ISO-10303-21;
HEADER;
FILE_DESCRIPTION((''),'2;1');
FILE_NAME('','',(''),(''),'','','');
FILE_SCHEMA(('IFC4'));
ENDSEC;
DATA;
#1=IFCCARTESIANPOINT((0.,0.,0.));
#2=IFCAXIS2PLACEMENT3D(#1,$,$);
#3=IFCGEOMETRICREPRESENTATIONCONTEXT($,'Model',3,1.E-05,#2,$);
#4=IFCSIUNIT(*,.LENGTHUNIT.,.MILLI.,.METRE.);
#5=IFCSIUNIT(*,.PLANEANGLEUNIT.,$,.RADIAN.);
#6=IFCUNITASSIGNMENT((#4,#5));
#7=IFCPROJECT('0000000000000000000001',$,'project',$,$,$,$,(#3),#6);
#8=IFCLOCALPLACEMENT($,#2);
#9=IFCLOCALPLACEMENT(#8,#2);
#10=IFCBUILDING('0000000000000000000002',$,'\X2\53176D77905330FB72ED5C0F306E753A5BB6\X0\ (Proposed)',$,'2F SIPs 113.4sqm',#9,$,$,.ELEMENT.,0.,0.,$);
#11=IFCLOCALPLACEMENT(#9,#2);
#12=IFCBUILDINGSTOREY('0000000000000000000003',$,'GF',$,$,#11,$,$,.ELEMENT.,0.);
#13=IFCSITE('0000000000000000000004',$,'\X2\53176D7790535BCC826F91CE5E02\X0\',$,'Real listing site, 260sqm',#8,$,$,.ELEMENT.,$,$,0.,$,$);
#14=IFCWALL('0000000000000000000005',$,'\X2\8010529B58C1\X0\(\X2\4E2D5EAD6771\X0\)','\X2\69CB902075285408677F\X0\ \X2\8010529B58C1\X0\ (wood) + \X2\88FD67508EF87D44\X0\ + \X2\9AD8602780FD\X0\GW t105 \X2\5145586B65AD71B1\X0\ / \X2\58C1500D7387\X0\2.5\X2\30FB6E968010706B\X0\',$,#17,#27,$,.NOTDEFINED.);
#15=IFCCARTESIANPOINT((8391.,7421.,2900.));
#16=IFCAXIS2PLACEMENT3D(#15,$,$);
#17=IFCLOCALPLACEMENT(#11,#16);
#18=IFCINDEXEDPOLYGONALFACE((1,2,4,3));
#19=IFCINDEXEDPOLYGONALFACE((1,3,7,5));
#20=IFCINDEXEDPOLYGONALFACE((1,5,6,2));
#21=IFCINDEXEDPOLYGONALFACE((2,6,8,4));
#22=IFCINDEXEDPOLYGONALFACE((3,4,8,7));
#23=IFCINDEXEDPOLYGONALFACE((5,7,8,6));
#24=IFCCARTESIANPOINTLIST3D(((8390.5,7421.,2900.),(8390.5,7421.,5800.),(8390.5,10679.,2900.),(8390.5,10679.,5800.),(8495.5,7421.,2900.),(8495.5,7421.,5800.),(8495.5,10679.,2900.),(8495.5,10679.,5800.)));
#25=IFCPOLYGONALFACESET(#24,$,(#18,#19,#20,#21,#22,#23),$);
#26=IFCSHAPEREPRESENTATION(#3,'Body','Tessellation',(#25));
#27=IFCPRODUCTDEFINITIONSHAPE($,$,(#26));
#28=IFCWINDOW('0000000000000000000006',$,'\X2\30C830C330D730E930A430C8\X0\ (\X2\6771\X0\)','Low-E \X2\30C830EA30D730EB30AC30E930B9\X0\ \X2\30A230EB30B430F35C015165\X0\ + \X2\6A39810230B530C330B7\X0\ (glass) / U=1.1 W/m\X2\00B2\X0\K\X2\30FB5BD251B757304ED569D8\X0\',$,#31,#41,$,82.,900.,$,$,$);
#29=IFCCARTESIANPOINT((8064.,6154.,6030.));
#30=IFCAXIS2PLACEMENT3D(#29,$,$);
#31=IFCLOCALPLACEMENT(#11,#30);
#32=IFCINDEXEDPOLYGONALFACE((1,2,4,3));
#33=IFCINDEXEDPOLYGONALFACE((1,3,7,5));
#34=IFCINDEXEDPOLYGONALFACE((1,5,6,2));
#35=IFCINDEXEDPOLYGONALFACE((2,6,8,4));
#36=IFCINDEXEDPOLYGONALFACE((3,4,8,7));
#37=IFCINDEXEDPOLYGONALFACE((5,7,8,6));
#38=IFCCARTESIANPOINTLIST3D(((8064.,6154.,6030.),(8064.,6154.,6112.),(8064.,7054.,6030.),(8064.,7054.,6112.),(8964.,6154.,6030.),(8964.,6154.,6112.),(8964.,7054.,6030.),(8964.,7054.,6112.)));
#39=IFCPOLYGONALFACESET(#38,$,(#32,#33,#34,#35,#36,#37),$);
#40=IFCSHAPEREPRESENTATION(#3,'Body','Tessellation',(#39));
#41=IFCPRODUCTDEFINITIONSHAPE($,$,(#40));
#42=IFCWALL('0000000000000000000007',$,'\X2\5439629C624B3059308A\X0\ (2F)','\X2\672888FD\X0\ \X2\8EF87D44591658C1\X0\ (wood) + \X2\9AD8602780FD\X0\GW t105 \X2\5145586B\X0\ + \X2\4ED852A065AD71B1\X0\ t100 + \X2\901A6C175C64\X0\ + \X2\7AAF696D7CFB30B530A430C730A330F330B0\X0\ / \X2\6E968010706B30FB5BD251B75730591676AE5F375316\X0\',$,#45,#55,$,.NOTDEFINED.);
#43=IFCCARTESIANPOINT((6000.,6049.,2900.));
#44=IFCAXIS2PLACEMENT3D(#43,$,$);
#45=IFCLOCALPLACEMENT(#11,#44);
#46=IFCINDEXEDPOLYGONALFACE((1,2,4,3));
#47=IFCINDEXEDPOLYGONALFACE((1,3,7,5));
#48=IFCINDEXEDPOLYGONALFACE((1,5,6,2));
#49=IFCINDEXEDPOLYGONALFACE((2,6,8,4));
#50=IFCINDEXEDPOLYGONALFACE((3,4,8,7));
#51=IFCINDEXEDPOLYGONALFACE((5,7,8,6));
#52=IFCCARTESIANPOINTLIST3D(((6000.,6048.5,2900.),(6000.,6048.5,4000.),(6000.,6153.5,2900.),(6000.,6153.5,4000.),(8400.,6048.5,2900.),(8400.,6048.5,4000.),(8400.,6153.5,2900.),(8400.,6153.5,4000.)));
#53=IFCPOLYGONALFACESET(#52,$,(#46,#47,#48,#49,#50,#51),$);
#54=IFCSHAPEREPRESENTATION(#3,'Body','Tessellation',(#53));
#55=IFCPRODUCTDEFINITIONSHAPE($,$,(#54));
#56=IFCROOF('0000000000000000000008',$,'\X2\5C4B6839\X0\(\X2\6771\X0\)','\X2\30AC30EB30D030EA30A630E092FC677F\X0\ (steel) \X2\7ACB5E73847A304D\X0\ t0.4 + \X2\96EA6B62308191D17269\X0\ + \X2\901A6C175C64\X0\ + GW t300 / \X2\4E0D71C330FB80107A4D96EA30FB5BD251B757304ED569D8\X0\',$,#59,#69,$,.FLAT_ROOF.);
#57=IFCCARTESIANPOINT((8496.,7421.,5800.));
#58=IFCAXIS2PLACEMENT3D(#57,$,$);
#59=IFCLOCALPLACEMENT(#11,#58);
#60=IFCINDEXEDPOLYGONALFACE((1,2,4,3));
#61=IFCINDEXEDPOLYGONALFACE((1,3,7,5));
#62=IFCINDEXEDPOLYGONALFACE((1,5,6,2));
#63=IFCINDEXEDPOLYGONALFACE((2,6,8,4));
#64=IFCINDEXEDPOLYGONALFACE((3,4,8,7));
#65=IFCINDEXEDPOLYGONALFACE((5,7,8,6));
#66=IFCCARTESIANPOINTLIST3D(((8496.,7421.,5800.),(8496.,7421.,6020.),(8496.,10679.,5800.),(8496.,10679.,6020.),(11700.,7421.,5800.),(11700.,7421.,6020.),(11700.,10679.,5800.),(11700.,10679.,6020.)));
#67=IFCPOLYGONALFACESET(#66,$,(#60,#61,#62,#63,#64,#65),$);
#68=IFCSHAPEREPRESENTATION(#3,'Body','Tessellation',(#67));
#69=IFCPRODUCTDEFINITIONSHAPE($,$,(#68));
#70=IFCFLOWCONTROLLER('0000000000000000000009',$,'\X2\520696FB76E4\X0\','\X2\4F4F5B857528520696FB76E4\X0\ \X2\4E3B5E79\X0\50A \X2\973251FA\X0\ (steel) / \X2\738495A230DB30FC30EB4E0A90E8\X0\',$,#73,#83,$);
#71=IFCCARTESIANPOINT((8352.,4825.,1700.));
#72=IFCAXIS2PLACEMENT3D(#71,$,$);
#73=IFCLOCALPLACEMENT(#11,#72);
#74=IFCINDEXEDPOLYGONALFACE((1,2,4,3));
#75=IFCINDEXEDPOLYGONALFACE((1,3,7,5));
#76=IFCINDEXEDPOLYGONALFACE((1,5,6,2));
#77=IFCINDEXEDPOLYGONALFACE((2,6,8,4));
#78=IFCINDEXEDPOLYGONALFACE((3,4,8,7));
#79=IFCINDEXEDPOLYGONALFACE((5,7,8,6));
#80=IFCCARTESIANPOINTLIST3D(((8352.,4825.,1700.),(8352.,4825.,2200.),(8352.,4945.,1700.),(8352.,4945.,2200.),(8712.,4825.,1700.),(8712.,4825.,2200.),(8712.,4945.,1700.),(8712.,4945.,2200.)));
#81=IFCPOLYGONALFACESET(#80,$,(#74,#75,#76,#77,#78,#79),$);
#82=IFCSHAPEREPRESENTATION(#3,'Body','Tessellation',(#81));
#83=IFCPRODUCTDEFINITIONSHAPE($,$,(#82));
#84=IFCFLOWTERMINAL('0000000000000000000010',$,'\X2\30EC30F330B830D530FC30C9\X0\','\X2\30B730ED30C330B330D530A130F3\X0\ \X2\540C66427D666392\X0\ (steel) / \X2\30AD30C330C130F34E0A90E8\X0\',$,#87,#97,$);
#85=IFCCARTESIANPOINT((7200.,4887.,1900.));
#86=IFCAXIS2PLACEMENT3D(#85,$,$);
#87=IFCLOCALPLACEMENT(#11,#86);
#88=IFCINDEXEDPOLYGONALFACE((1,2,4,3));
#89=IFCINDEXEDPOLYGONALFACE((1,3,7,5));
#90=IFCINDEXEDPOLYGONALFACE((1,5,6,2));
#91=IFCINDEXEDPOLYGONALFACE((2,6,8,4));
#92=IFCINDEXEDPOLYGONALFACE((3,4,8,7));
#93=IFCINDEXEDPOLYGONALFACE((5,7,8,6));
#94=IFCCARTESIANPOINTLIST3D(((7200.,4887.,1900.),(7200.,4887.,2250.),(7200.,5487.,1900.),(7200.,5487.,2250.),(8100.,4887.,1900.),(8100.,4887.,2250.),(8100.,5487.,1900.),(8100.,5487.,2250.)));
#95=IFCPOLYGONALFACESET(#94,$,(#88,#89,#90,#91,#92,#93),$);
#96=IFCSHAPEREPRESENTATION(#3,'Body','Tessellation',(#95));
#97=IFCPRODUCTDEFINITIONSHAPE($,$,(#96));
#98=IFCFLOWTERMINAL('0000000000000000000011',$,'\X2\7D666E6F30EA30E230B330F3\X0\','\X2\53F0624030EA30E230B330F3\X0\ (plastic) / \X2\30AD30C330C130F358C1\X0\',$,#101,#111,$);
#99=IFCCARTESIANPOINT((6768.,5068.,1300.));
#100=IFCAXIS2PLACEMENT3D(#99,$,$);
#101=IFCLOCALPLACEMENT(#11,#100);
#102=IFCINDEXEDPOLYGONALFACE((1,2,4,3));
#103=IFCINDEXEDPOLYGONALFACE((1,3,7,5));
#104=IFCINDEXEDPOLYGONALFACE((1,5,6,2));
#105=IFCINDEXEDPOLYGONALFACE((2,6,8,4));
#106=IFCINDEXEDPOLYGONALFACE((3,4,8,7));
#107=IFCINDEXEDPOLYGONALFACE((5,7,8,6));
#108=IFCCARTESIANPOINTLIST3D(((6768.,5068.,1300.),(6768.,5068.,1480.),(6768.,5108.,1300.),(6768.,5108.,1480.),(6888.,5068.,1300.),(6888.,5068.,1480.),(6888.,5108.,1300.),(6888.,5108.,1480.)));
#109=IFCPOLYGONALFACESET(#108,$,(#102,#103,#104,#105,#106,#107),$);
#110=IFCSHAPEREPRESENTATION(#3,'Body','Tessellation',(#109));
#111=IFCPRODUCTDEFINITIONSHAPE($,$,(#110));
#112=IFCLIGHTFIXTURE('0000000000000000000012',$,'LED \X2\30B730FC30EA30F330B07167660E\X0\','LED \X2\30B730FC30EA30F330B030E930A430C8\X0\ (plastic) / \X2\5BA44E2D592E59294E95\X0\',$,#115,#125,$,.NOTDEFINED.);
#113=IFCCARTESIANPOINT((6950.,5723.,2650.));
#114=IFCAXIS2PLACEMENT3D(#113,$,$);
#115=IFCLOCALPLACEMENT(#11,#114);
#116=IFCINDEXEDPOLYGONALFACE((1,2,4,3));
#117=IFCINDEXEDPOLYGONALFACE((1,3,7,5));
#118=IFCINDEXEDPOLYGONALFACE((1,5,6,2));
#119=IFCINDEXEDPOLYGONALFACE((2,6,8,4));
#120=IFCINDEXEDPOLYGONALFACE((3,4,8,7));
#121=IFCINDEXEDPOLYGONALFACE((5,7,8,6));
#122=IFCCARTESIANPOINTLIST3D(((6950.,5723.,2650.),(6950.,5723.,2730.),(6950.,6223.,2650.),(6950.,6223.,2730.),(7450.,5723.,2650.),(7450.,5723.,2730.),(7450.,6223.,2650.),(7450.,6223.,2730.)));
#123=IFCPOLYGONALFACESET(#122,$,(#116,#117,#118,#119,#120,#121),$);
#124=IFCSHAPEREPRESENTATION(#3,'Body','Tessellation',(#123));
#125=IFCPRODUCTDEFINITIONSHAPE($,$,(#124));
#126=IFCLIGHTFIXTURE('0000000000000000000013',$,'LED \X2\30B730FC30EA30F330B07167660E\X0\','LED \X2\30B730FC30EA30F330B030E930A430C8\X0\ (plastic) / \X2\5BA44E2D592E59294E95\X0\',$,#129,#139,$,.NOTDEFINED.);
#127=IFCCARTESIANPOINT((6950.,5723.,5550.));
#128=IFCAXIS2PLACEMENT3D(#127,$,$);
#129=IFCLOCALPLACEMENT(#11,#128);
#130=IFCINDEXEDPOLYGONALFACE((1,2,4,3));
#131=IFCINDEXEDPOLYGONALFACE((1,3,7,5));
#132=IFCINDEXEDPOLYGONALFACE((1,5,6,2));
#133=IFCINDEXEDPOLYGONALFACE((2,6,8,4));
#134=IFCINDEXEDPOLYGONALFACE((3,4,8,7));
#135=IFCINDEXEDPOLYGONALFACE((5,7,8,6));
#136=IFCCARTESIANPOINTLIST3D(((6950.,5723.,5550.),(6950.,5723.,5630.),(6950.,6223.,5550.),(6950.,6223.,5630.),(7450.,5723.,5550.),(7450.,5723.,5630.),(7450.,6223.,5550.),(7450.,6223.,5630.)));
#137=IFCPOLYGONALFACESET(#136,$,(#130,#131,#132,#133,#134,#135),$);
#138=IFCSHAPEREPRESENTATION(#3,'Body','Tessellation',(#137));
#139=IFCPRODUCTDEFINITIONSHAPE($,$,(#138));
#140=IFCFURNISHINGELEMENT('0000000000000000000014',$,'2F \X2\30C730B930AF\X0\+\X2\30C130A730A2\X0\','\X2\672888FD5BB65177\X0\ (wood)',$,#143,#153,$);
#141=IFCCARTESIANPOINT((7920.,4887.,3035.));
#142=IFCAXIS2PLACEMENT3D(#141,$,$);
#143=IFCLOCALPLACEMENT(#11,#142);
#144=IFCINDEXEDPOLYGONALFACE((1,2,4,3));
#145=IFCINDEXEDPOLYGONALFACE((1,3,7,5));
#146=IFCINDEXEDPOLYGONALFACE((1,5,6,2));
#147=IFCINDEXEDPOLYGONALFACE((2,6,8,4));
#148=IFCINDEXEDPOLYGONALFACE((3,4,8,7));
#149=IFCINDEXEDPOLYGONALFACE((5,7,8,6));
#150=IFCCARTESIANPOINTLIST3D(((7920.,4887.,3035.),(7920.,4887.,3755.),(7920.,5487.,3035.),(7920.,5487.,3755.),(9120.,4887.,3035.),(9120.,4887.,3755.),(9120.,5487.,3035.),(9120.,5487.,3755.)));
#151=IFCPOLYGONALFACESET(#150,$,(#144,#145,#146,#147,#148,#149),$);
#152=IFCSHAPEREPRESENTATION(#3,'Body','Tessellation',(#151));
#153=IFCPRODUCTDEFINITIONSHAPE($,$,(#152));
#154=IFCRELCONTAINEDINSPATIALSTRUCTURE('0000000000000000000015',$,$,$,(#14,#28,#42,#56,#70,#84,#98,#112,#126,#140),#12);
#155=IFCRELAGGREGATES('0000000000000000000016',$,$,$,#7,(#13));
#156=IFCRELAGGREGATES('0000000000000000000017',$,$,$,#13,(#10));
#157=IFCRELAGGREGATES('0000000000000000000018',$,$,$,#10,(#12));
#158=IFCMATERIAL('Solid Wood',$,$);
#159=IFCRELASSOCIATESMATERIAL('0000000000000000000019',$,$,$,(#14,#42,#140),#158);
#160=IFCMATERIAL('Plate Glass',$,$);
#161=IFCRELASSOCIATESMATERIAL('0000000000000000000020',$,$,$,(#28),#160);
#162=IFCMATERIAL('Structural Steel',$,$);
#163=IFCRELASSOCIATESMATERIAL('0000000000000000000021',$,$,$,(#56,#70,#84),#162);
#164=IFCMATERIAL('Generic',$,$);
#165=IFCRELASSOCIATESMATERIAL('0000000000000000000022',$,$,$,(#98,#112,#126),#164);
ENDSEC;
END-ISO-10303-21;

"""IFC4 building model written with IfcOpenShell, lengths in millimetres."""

from ifc_helpers import new_model, si_unit, frame, frame_2d, origin, place, context, project, spatial, rectangle, extrude, material, element, save


model = new_model("IFC4")

# Units and contexts
model_context = context("Model", 3, precision=1e-05, world=origin())
ifc_project = project(units=[si_unit("LENGTHUNIT", "METRE", prefix="MILLI"), si_unit("PLANEANGLEUNIT", "RADIAN")], contexts=[model_context])

# Site, building, storey
site_placement = place(None, origin())
site = spatial("IfcSite", under=ifc_project, at=site_placement, Name="北海道富良野市", ObjectType="Real listing site, 260sqm", CompositionType="ELEMENT", RefElevation=0.0)
building_placement = place(site_placement, origin())
building = spatial("IfcBuilding", under=site, at=building_placement, Name="北海道・狭小の町家 (Proposed)", ObjectType="2F SIPs 113.4sqm", CompositionType="ELEMENT", ElevationOfRefHeight=0.0, ElevationOfTerrain=0.0)
storey_placement = place(building_placement, origin())
storey = spatial("IfcBuildingStorey", under=building, at=storey_placement, Name="GF", CompositionType="ELEMENT", Elevation=0.0)

# Shared definitions
ifc_material_1 = material(Name="Solid Wood")

# Shared definitions
ifc_material_2 = material(Name="Plate Glass")

# Wall
wall_1_placement = place(storey_placement, frame((8391.0, 7421.0, 2900.0)))
element("IfcWall", 1, at=wall_1_placement, inside=storey, material=ifc_material_1, Name="耐力壁(中庭東)", Description="構造用合板 耐力壁 (wood) + 製材軸組 + 高性能GW t105 充填断熱 / 壁倍率2.5・準耐火", PredefinedType="NOTDEFINED", context=model_context, shape_type="SweptSolid", body=[
    extrude(rectangle(XDim=105.0, YDim=3258.0, at=frame_2d((52.0, 1629.0))), frame((8391.0, 7421.0, 2900.0)), (0.0, 0.0, 1.0), 2900.0),
])

# Window
window_1_placement = place(storey_placement, frame((8064.0, 6154.0, 6030.0)))
element("IfcWindow", 2, at=window_1_placement, inside=storey, material=ifc_material_2, Name="トップライト (東)", Description="Low-E トリプルガラス アルゴン封入 + 樹脂サッシ (glass) / U=1.1 W/m²K・寒冷地仕様", OverallHeight=82.0, OverallWidth=900.0, context=model_context, shape_type="SweptSolid", body=[
    extrude(rectangle(XDim=900.0, YDim=900.0, at=frame_2d((450.0, 450.0))), frame((8064.0, 6154.0, 6030.0)), (0.0, 0.0, 1.0), 82.0),
])

# Wall
wall_2_placement = place(storey_placement, frame((6000.0, 6049.0, 2900.0)))
element("IfcWall", 3, at=wall_2_placement, inside=storey, material=ifc_material_1, Name="吹抜手すり (2F)", Description="木製 軸組外壁 (wood) + 高性能GW t105 充填 + 付加断熱 t100 + 通気層 + 窯業系サイディング / 準耐火・寒冷地外皮強化", PredefinedType="NOTDEFINED", context=model_context, shape_type="SweptSolid", body=[
    extrude(rectangle(XDim=2400.0, YDim=105.0, at=frame_2d((1200.0, 52.0))), frame((6000.0, 6049.0, 2900.0)), (0.0, 0.0, 1.0), 1100.0),
])

# Roof
ifc_material_3 = material(Name="Structural Steel")
for number, where, name in (
    (4, (8496.0, 7421.0, 5800.0), "屋根(東)"),
):
    element("IfcRoof", number, at=place(storey_placement, frame(where)), inside=storey, material=ifc_material_3, Name=name, Description="ガルバリウム鋼板 (steel) 立平葺き t0.4 + 雪止め金物 + 通気層 + GW t300 / 不燃・耐積雪・寒冷地仕様", PredefinedType="FLAT_ROOF", context=model_context, shape_type="SweptSolid", body=[
        extrude(rectangle(XDim=3204.0, YDim=3258.0, at=frame_2d((1602.0, 1629.0))), frame((8496.0, 7421.0, 5800.0)), (0.0, 0.0, 1.0), 220.0),
    ])

# Flow controller
flow_controller_placement = place(storey_placement, frame((8352.0, 4825.0, 1700.0)))
element("IfcFlowController", 5, at=flow_controller_placement, inside=storey, material=ifc_material_3, Name="分電盤", Description="住宅用分電盤 主幹50A 露出 (steel) / 玄関ホール上部", context=model_context, shape_type="SweptSolid", body=[
    extrude(rectangle(XDim=360.0, YDim=120.0, at=frame_2d((180.0, 60.0))), frame((8352.0, 4825.0, 1700.0)), (0.0, 0.0, 1.0), 500.0),
])

# Flow terminals
flow_terminal_1_placement = place(storey_placement, frame((7200.0, 4887.0, 1900.0)))
element("IfcFlowTerminal", 6, at=flow_terminal_1_placement, inside=storey, material=ifc_material_3, Name="レンジフード", Description="シロッコファン 同時給排 (steel) / キッチン上部", context=model_context, shape_type="SweptSolid", body=[
    extrude(rectangle(XDim=900.0, YDim=600.0, at=frame_2d((450.0, 300.0))), frame((7200.0, 4887.0, 1900.0)), (0.0, 0.0, 1.0), 350.0),
])
ifc_material_4 = material(Name="Generic")
flow_terminal_2_placement = place(storey_placement, frame((6768.0, 5068.0, 1300.0)))
element("IfcFlowTerminal", 7, at=flow_terminal_2_placement, inside=storey, material=ifc_material_4, Name="給湯リモコン", Description="台所リモコン (plastic) / キッチン壁", context=model_context, shape_type="SweptSolid", body=[
    extrude(rectangle(XDim=120.0, YDim=40.0, at=frame_2d((60.0, 20.0))), frame((6768.0, 5068.0, 1300.0)), (0.0, 0.0, 1.0), 180.0),
])

# Light fixtures
light_fixture_1_placement = place(storey_placement, frame((6950.0, 5723.0, 2650.0)))
element("IfcLightFixture", 8, at=light_fixture_1_placement, inside=storey, material=ifc_material_4, Name="LED シーリング照明", Description="LED シーリングライト (plastic) / 室中央天井", PredefinedType="NOTDEFINED", context=model_context, shape_type="SweptSolid", body=[
    extrude(rectangle(XDim=500.0, YDim=500.0, at=frame_2d((250.0, 250.0))), frame((6950.0, 5723.0, 2650.0)), (0.0, 0.0, 1.0), 80.0),
])
light_fixture_2_placement = place(storey_placement, frame((6950.0, 5723.0, 5550.0)))
element("IfcLightFixture", 9, at=light_fixture_2_placement, inside=storey, material=ifc_material_4, Name="LED シーリング照明", Description="LED シーリングライト (plastic) / 室中央天井", PredefinedType="NOTDEFINED", context=model_context, shape_type="SweptSolid", body=[
    extrude(rectangle(XDim=500.0, YDim=500.0, at=frame_2d((250.0, 250.0))), frame((6950.0, 5723.0, 5550.0)), (0.0, 0.0, 1.0), 80.0),
])

# Furnishing element
furnishing_placement = place(storey_placement, frame((7920.0, 4887.0, 3035.0)))
element("IfcFurnishingElement", 10, at=furnishing_placement, inside=storey, material=ifc_material_1, Name="2F デスク+チェア", Description="木製家具 (wood)", context=model_context, shape_type="SweptSolid", body=[
    extrude(rectangle(XDim=1200.0, YDim=600.0, at=frame_2d((600.0, 300.0))), frame((7920.0, 4887.0, 3035.0)), (0.0, 0.0, 1.0), 720.0),
])

save(model, "model.ifc")
